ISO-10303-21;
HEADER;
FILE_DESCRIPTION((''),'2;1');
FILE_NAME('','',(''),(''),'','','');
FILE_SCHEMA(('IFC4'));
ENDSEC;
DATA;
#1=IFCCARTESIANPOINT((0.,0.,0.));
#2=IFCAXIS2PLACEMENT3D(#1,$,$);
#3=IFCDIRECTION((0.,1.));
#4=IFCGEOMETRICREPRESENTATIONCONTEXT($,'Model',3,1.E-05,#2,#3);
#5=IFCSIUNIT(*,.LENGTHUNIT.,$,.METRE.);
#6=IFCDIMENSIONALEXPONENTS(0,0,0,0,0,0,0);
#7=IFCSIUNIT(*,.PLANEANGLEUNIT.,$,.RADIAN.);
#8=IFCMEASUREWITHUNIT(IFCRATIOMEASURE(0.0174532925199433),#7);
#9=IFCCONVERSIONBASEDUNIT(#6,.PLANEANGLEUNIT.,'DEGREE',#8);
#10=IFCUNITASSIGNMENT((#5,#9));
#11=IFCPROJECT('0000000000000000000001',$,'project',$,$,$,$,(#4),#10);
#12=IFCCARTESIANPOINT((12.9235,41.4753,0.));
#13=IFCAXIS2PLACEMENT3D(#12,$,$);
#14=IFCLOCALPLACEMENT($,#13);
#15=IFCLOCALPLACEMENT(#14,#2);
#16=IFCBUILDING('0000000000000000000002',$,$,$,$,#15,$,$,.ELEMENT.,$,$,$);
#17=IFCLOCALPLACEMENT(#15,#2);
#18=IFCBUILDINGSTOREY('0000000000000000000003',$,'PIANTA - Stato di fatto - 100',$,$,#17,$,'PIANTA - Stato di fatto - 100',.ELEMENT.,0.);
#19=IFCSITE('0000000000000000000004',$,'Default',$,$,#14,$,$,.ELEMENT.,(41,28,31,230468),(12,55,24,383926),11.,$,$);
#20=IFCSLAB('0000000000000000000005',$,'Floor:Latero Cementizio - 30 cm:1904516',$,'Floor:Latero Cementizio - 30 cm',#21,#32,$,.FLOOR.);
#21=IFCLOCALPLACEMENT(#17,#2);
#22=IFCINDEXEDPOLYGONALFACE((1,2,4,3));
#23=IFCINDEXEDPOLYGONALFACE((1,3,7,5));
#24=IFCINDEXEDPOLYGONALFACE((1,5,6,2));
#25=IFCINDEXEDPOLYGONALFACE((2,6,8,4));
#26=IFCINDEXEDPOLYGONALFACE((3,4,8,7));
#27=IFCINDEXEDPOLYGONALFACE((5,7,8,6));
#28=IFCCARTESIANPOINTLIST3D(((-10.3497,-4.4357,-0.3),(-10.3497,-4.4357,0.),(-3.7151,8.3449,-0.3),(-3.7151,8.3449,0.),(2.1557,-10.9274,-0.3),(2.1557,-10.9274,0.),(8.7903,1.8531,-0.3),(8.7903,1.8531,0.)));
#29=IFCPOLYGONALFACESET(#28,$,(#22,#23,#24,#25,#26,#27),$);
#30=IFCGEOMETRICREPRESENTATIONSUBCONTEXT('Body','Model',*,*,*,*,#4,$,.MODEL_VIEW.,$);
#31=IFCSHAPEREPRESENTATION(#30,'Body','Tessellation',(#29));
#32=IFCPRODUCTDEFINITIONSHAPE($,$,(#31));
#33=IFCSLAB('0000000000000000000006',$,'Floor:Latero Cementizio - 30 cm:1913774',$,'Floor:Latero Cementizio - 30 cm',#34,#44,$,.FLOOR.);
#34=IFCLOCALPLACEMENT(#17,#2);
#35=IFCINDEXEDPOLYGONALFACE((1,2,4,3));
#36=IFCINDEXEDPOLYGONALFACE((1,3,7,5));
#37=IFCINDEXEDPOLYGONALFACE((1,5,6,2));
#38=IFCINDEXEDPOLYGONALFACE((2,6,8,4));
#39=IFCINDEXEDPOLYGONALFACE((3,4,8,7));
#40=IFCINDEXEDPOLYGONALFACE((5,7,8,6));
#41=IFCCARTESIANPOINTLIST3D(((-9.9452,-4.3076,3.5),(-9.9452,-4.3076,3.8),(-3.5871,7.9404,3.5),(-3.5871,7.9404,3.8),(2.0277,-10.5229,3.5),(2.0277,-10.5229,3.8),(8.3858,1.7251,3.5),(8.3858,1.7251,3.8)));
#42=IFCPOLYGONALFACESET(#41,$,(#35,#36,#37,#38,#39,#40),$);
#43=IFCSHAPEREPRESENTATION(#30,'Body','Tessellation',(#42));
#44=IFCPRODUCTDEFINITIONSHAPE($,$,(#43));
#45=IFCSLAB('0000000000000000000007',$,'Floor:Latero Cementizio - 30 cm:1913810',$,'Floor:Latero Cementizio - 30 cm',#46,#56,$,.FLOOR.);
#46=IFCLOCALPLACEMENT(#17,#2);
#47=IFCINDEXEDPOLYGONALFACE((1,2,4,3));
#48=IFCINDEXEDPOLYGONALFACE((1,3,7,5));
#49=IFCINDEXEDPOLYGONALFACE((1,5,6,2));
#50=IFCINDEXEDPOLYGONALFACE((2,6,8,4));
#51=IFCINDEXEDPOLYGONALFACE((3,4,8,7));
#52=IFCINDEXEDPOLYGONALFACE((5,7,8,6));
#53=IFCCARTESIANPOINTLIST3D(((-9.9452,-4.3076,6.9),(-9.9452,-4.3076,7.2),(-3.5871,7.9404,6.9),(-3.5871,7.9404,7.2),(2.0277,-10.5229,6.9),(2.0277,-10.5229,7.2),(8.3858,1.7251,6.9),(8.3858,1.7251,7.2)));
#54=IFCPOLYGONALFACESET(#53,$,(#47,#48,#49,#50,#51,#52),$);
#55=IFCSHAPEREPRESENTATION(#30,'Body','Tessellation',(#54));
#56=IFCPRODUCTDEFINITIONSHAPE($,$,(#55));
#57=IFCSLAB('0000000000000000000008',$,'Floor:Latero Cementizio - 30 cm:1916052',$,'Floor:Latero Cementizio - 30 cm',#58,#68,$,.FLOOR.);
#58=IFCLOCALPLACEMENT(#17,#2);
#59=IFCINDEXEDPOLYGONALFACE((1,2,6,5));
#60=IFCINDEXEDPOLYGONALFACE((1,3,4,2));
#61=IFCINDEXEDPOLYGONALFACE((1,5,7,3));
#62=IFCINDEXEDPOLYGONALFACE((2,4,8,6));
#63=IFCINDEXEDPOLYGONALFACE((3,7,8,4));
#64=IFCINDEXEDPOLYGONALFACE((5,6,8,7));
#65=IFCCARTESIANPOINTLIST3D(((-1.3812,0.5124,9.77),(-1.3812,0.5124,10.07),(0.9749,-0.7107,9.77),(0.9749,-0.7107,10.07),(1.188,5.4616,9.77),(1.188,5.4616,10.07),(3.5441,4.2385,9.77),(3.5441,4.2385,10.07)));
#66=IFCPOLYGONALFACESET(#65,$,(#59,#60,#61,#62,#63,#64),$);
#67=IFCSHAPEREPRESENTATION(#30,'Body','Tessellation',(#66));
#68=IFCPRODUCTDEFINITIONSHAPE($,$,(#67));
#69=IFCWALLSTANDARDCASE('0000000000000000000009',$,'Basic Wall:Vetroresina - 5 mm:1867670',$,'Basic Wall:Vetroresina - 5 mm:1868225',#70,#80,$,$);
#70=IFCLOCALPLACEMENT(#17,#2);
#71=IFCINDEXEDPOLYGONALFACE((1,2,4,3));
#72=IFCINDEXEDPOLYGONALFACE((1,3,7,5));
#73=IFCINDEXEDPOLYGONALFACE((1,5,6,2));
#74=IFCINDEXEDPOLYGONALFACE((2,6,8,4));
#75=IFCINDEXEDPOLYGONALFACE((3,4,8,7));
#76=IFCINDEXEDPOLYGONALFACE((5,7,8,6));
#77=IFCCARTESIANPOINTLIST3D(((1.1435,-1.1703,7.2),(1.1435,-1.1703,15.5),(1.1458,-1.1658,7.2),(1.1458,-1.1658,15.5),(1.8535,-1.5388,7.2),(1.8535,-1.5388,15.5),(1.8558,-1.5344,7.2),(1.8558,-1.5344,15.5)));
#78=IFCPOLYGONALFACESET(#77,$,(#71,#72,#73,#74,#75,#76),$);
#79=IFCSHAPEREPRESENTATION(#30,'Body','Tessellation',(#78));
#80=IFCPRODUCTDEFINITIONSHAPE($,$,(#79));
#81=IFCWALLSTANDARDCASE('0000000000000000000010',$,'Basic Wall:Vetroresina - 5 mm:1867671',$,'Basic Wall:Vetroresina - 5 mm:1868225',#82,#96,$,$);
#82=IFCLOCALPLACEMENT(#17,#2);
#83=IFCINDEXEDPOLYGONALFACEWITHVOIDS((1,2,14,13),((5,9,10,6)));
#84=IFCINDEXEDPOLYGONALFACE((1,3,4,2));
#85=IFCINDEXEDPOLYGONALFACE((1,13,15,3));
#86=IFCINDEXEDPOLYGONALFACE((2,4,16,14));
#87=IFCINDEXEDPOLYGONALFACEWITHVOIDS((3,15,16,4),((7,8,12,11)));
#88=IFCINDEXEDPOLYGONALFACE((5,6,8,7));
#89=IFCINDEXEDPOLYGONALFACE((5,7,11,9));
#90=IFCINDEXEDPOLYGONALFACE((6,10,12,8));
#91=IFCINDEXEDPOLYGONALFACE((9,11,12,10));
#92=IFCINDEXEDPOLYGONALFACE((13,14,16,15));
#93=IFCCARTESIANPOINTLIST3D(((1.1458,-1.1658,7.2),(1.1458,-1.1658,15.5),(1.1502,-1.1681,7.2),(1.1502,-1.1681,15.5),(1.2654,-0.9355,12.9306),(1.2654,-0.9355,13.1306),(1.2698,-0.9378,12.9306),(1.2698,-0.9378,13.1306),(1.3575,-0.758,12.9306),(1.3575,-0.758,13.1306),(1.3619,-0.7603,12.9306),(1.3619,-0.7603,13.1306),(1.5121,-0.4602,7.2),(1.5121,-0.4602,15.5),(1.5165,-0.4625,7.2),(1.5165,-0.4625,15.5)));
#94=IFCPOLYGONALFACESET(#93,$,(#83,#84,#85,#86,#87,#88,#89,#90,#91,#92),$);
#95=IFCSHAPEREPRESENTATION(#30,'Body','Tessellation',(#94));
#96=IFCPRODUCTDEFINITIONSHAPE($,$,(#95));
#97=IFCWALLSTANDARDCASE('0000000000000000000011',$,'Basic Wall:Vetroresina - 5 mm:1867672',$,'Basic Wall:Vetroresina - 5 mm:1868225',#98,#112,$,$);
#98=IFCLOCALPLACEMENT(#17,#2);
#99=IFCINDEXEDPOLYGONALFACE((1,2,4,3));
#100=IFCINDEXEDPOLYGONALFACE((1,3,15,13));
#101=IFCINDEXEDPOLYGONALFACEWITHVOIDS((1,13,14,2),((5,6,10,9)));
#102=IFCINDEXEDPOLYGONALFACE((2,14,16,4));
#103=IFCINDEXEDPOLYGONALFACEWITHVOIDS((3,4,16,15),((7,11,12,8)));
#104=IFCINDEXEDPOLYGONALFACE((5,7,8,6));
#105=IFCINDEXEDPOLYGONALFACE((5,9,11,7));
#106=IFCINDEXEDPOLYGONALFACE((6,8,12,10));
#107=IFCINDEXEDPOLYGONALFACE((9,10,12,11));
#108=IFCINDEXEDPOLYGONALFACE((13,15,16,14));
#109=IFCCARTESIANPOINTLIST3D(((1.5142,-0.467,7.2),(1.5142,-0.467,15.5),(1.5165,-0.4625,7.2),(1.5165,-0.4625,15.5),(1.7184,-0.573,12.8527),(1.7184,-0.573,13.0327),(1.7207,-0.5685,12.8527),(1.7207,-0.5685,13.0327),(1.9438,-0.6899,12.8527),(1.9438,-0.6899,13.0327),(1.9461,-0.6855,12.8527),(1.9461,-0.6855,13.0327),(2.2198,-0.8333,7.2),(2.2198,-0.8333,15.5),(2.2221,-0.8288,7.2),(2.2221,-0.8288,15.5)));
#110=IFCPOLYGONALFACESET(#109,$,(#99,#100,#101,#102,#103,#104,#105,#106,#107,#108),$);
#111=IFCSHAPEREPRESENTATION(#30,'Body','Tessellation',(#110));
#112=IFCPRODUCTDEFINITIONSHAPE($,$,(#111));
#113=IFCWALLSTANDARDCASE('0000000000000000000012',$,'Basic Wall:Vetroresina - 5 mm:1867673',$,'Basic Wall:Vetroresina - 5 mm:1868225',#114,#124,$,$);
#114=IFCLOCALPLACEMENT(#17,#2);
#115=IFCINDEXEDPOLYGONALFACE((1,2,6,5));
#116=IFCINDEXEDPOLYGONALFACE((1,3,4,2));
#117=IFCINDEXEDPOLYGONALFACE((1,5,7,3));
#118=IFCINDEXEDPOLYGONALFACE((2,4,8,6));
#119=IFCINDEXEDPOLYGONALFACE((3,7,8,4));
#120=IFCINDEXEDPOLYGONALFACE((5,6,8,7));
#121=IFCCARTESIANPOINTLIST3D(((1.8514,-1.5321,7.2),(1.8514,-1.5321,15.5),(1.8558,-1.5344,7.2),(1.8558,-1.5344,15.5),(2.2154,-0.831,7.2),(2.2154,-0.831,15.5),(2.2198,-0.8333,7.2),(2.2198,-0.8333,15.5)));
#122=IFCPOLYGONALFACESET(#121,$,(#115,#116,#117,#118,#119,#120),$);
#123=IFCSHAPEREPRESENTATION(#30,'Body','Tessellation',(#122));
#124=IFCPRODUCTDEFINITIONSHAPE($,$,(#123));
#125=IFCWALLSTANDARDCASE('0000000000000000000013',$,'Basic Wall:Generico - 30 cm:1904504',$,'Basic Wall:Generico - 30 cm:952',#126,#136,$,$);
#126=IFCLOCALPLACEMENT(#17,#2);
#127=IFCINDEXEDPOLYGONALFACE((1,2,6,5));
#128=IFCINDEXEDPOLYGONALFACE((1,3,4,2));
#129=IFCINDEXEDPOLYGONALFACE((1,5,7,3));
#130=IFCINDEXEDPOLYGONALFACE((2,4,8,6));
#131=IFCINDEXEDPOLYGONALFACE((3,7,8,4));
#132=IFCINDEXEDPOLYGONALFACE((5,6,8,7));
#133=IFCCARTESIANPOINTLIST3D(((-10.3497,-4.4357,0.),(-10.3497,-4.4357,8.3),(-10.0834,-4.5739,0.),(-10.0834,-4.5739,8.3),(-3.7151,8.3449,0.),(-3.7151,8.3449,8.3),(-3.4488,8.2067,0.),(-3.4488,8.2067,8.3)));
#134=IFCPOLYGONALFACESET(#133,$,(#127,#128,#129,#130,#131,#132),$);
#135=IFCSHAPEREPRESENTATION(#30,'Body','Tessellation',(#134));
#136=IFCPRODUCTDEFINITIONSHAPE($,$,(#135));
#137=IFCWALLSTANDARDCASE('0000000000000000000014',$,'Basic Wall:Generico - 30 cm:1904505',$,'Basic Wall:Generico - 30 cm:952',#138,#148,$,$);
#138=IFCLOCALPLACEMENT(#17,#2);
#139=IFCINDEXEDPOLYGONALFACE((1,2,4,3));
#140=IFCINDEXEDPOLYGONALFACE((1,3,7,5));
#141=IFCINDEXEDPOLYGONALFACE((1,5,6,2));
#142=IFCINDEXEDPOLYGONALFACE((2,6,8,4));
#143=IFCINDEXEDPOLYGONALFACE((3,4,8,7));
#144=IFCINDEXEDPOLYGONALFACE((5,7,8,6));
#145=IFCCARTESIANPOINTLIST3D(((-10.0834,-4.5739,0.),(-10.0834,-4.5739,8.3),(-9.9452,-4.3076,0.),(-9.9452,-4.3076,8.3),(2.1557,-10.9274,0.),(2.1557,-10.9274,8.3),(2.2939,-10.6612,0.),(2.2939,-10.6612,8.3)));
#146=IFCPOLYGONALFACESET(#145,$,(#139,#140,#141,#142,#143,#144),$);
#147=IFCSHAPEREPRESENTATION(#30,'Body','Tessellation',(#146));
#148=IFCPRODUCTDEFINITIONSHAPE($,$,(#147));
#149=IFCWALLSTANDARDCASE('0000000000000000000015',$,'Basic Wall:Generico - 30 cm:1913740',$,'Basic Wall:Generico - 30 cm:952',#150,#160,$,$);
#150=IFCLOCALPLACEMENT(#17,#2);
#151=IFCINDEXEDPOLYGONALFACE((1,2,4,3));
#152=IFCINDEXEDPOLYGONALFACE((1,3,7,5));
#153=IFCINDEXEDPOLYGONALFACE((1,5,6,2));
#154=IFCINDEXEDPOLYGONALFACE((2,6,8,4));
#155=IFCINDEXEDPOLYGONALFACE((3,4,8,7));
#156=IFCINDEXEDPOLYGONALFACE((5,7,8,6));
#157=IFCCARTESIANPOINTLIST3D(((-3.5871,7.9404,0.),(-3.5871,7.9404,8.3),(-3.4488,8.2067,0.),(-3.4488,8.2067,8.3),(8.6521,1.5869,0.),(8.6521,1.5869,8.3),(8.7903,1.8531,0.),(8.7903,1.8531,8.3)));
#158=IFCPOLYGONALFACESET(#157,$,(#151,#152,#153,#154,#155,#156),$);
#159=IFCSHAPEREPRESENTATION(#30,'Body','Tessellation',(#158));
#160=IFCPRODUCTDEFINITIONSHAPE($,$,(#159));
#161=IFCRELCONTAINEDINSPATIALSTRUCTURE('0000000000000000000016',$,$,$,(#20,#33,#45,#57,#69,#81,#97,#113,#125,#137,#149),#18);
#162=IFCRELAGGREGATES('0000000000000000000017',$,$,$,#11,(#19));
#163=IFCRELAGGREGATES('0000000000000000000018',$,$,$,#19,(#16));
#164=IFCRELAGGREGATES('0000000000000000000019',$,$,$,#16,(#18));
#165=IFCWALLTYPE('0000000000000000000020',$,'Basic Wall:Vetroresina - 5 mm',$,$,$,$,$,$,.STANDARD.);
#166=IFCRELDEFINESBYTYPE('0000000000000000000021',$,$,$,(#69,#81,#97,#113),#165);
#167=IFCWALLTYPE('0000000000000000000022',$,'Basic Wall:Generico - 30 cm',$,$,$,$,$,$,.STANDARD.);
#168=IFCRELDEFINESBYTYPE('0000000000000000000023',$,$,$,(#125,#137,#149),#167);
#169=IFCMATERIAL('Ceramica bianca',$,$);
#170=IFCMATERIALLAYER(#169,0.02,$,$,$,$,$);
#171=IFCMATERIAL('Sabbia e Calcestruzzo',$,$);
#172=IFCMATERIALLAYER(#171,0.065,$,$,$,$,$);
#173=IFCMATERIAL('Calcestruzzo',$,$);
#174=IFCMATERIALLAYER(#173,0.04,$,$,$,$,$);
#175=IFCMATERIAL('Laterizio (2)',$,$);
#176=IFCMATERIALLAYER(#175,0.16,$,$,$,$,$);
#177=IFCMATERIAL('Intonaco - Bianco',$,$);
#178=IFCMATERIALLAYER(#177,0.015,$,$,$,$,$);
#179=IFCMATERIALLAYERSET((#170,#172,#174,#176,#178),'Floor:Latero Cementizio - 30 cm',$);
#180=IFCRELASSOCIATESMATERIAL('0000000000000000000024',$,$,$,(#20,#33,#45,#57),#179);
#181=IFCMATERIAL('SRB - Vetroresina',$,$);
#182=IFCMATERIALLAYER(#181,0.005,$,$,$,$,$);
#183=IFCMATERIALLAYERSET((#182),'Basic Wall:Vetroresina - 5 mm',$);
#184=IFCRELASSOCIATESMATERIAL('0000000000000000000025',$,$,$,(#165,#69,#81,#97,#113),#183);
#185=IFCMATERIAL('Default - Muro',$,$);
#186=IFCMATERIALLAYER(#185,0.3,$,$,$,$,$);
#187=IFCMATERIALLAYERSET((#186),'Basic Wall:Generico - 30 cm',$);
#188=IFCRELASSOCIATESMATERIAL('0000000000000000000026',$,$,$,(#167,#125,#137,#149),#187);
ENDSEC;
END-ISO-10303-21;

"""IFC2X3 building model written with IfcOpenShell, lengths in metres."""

from ifc_helpers import new_model, entity, si_unit, converted_unit, direction, frame, frame_2d, origin, origin_2d_with_axis, place, context, subcontext, project, spatial, rectangle, extrude, material, layer, layer_set, layer_usage, type_object, element, save


model = new_model("IFC2X3")

# Units and contexts
model_context = context("Model", 3, precision=1e-05, world=origin(), true_north=direction((0.0, 1.0)))
body_context = subcontext(model_context, "Body", "Model", "MODEL_VIEW")
ifc_project = project(units=[si_unit("LENGTHUNIT", "METRE"), converted_unit("PLANEANGLEUNIT", "DEGREE", entity("IfcRatioMeasure", 0.0174532925199433), si_unit("PLANEANGLEUNIT", "RADIAN"), dimensions=[0, 0, 0, 0, 0, 0, 0])], contexts=[model_context])

# Site, building, storey
site_placement = place(None, frame((12.9235, 41.4753, 0.0)))
site = spatial("IfcSite", under=ifc_project, at=site_placement, Name="Default", CompositionType="ELEMENT", RefLatitude=(41, 28, 31, 230468), RefLongitude=(12, 55, 24, 383926), RefElevation=11.0)
building_placement = place(site_placement, origin())
building = spatial("IfcBuilding", under=site, at=building_placement, CompositionType="ELEMENT")
storey_placement = place(building_placement, origin())
storey = spatial("IfcBuildingStorey", under=building, at=storey_placement, Name="PIANTA - Stato di fatto - 100", LongName="PIANTA - Stato di fatto - 100", CompositionType="ELEMENT", Elevation=0.0)

# Slabs
ifc_material_1 = material(Name="Ceramica bianca")
ifc_layer_1 = layer(ifc_material_1, 0.02)
ifc_material_2 = material(Name="Sabbia e Calcestruzzo")
ifc_layer_2 = layer(ifc_material_2, 0.065)
ifc_material_3 = material(Name="Calcestruzzo")
ifc_layer_3 = layer(ifc_material_3, 0.04)
ifc_material_4 = material(Name="Laterizio (2)")
ifc_layer_4 = layer(ifc_material_4, 0.16)
ifc_material_5 = material(Name="Intonaco - Bianco")
ifc_layer_5 = layer(ifc_material_5, 0.015)
ifc_layer_set_1 = layer_set([ifc_layer_1, ifc_layer_2, ifc_layer_3, ifc_layer_4, ifc_layer_5], Name="Floor:Latero Cementizio - 30 cm")
ifc_layer_usage_1 = layer_usage(ifc_layer_set_1, "AXIS3", "POSITIVE", 0.0)
slab_1_placement = place(storey_placement, origin())
element("IfcSlab", 1, at=slab_1_placement, inside=storey, material=ifc_layer_usage_1, Name="Floor:Latero Cementizio - 30 cm:1904516", ObjectType="Floor:Latero Cementizio - 30 cm", PredefinedType="FLOOR", context=body_context, shape_type="SweptSolid", body=[
    extrude(rectangle(XDim=14.09, YDim=14.4, at=frame_2d((0.0, 0.0), x_axis=(1.0, 0.0))), frame((-0.7797, -1.2913, 0.0), z_axis=(0.0, 0.0, -1.0), x_axis=(0.887538, -0.460735, 0.0)), (0.0, 0.0, 1.0), 0.3),
])
ifc_layer_usage_2 = layer_usage(ifc_layer_set_1, "AXIS3", "POSITIVE", 0.0)
slab_2_placement = place(storey_placement, origin())
element("IfcSlab", 2, at=slab_2_placement, inside=storey, material=ifc_layer_usage_2, Name="Floor:Latero Cementizio - 30 cm:1913774", ObjectType="Floor:Latero Cementizio - 30 cm", PredefinedType="FLOOR", context=body_context, shape_type="SweptSolid", body=[
    extrude(rectangle(XDim=13.8, YDim=13.49, at=frame_2d((0.0, 0.0), x_axis=(1.0, 0.0))), frame((-0.7797, -1.2913, 3.8), z_axis=(0.0, 0.0, -1.0), x_axis=(-0.460735, -0.887538, 0.0)), (0.0, 0.0, 1.0), 0.3),
])
ifc_layer_usage_3 = layer_usage(ifc_layer_set_1, "AXIS3", "POSITIVE", 0.0)
slab_3_placement = place(storey_placement, origin())
element("IfcSlab", 3, at=slab_3_placement, inside=storey, material=ifc_layer_usage_3, Name="Floor:Latero Cementizio - 30 cm:1913810", ObjectType="Floor:Latero Cementizio - 30 cm", PredefinedType="FLOOR", context=body_context, shape_type="SweptSolid", body=[
    extrude(rectangle(XDim=13.8, YDim=13.49, at=frame_2d((0.0, 0.0), x_axis=(1.0, 0.0))), frame((-0.7797, -1.2913, 7.2), z_axis=(0.0, 0.0, -1.0), x_axis=(-0.460735, -0.887538, 0.0)), (0.0, 0.0, 1.0), 0.3),
])
ifc_layer_usage_4 = layer_usage(ifc_layer_set_1, "AXIS3", "POSITIVE", 0.0)
slab_4_placement = place(storey_placement, origin())
element("IfcSlab", 4, at=slab_4_placement, inside=storey, material=ifc_layer_usage_4, Name="Floor:Latero Cementizio - 30 cm:1916052", ObjectType="Floor:Latero Cementizio - 30 cm", PredefinedType="FLOOR", context=body_context, shape_type="SweptSolid", body=[
    extrude(rectangle(XDim=5.5763, YDim=2.6546, at=frame_2d((0.0, 0.0), x_axis=(1.0, 0.0))), frame((1.0815, 2.3754, 10.07), z_axis=(0.0, 0.0, -1.0), x_axis=(-0.460735, -0.887538, 0.0)), (0.0, 0.0, 1.0), 0.3),
])

# Wall
ifc_material_6 = material(Name="SRB - Vetroresina")
ifc_layer_6 = layer(ifc_material_6, 0.005)
ifc_layer_set_2 = layer_set([ifc_layer_6], Name="Basic Wall:Vetroresina - 5 mm")
ifc_layer_usage_5 = layer_usage(ifc_layer_set_2, "AXIS2", "NEGATIVE", 0.0025)
wall_type_1 = type_object("IfcWallType", Name="Basic Wall:Vetroresina - 5 mm", PredefinedType="STANDARD", material=ifc_layer_set_2)
wall_1_placement = place(storey_placement, frame((1.8547, -1.5366, 7.2), z_axis=(0.0, 0.0, 1.0), x_axis=(-0.887538, 0.460735, 0.0)))
element("IfcWallStandardCase", 5, at=wall_1_placement, inside=storey, type_object=wall_type_1, material=ifc_layer_usage_5, Name="Basic Wall:Vetroresina - 5 mm:1867670", ObjectType="Basic Wall:Vetroresina - 5 mm:1868225", context=body_context, shape_type="SweptSolid", body=[
    extrude(rectangle(XDim=0.8, YDim=0.005, at=frame_2d((0.4, 0.0), x_axis=(-1.0, 0.0))), origin(), (0.0, 0.0, 1.0), 8.3),
])

# Walls, openings
ifc_layer_usage_6 = layer_usage(ifc_layer_set_2, "AXIS2", "NEGATIVE", 0.0025)
wall_2_placement = place(storey_placement, frame((1.148, -1.167, 7.2), z_axis=(0.0, 0.0, 1.0), x_axis=(0.460735, 0.887538, 0.0)))
wall_2 = element("IfcWallStandardCase", 6, at=wall_2_placement, inside=storey, type_object=wall_type_1, material=ifc_layer_usage_6, Name="Basic Wall:Vetroresina - 5 mm:1867671", ObjectType="Basic Wall:Vetroresina - 5 mm:1868225", context=body_context, shape_type="SweptSolid", body=[
    extrude(rectangle(XDim=0.795, YDim=0.005, at=frame_2d((0.3975, 0.0), x_axis=(-1.0, 0.0))), origin(), (0.0, 0.0, 1.0), 8.3),
])
opening_1_placement = place(wall_2_placement, origin())
element("IfcOpeningElement", 7, at=opening_1_placement, cuts=wall_2, ObjectType="Opening", context=body_context, shape_type="SweptSolid", body=[
    extrude(rectangle(XDim=0.2, YDim=0.2, at=origin_2d_with_axis()), frame((0.3595, 0.0025, 5.8306), z_axis=(0.0, -1.0, 0.0), x_axis=(0.0, 0.0, -1.0)), (0.0, 0.0, 1.0), 0.005),
])
ifc_layer_usage_7 = layer_usage(ifc_layer_set_2, "AXIS2", "NEGATIVE", 0.0025)
wall_3_placement = place(storey_placement, frame((1.5154, -0.4648, 7.2), z_axis=(0.0, 0.0, 1.0), x_axis=(0.887538, -0.460735, 0.0)))
wall_3 = element("IfcWallStandardCase", 8, at=wall_3_placement, inside=storey, type_object=wall_type_1, material=ifc_layer_usage_7, Name="Basic Wall:Vetroresina - 5 mm:1867672", ObjectType="Basic Wall:Vetroresina - 5 mm:1868225", context=body_context, shape_type="SweptSolid", body=[
    extrude(rectangle(XDim=0.795, YDim=0.005, at=frame_2d((0.3975, 0.0), x_axis=(-1.0, 0.0))), origin(), (0.0, 0.0, 1.0), 8.3),
])
opening_2_placement = place(wall_3_placement, origin())
element("IfcOpeningElement", 9, at=opening_2_placement, cuts=wall_3, ObjectType="Opening", context=body_context, shape_type="SweptSolid", body=[
    extrude(rectangle(XDim=0.18, YDim=0.2539, at=frame_2d((0.0, 0.0), x_axis=(1.0, 0.0))), frame((0.357, 0.0025, 5.7427), z_axis=(0.0, -1.0, 0.0), x_axis=(0.0, 0.0, -1.0)), (0.0, 0.0, 1.0), 0.005),
])

# Walls
ifc_layer_usage_8 = layer_usage(ifc_layer_set_2, "AXIS2", "NEGATIVE", 0.0025)
wall_4_placement = place(storey_placement, frame((2.2176, -0.8321, 7.2), z_axis=(0.0, 0.0, 1.0), x_axis=(-0.460735, -0.887538, 0.0)))
element("IfcWallStandardCase", 10, at=wall_4_placement, inside=storey, type_object=wall_type_1, material=ifc_layer_usage_8, Name="Basic Wall:Vetroresina - 5 mm:1867673", ObjectType="Basic Wall:Vetroresina - 5 mm:1868225", context=body_context, shape_type="SweptSolid", body=[
    extrude(rectangle(XDim=0.79, YDim=0.005, at=frame_2d((0.395, 0.0), x_axis=(-1.0, 0.0))), origin(), (0.0, 0.0, 1.0), 8.3),
])
ifc_material_7 = material(Name="Default - Muro")
ifc_layer_7 = layer(ifc_material_7, 0.3)
ifc_layer_set_3 = layer_set([ifc_layer_7], Name="Basic Wall:Generico - 30 cm")
ifc_layer_usage_9 = layer_usage(ifc_layer_set_3, "AXIS2", "POSITIVE", -0.15)
wall_type_2 = type_object("IfcWallType", Name="Basic Wall:Generico - 30 cm", PredefinedType="STANDARD", material=ifc_layer_set_3)
wall_5_placement = place(storey_placement, frame((-3.582, 8.2758, 0.0), z_axis=(0.0, 0.0, 1.0), x_axis=(-0.460735, -0.887538, 0.0)))
element("IfcWallStandardCase", 11, at=wall_5_placement, inside=storey, type_object=wall_type_2, material=ifc_layer_usage_9, Name="Basic Wall:Generico - 30 cm:1904504", ObjectType="Basic Wall:Generico - 30 cm:952", context=body_context, shape_type="SweptSolid", body=[
    extrude(rectangle(XDim=14.4, YDim=0.3, at=frame_2d((7.2, 0.0), x_axis=(-1.0, 0.0))), origin(), (0.0, 0.0, 1.0), 8.3),
])
ifc_layer_usage_10 = layer_usage(ifc_layer_set_3, "AXIS2", "POSITIVE", -0.15)
wall_6_placement = place(storey_placement, frame((-10.0143, -4.4408, 0.0), z_axis=(0.0, 0.0, 1.0), x_axis=(0.887538, -0.460735, 0.0)))
element("IfcWallStandardCase", 12, at=wall_6_placement, inside=storey, type_object=wall_type_2, material=ifc_layer_usage_10, Name="Basic Wall:Generico - 30 cm:1904505", ObjectType="Basic Wall:Generico - 30 cm:952", context=body_context, shape_type="SweptSolid", body=[
    extrude(rectangle(XDim=13.79, YDim=0.3, at=frame_2d((6.895, 0.0), x_axis=(-1.0, 0.0))), origin(), (0.0, 0.0, 1.0), 8.3),
])
ifc_layer_usage_11 = layer_usage(ifc_layer_set_3, "AXIS2", "NEGATIVE", 0.15)
wall_7_placement = place(storey_placement, frame((-3.518, 8.0735, 0.0), z_axis=(0.0, 0.0, 1.0), x_axis=(0.887538, -0.460735, 0.0)))
element("IfcWallStandardCase", 13, at=wall_7_placement, inside=storey, type_object=wall_type_2, material=ifc_layer_usage_11, Name="Basic Wall:Generico - 30 cm:1913740", ObjectType="Basic Wall:Generico - 30 cm:952", context=body_context, shape_type="SweptSolid", body=[
    extrude(rectangle(XDim=13.79, YDim=0.3, at=frame_2d((6.895, 0.0), x_axis=(-1.0, 0.0))), origin(), (0.0, 0.0, 1.0), 8.3),
])

save(model, "model.ifc")
